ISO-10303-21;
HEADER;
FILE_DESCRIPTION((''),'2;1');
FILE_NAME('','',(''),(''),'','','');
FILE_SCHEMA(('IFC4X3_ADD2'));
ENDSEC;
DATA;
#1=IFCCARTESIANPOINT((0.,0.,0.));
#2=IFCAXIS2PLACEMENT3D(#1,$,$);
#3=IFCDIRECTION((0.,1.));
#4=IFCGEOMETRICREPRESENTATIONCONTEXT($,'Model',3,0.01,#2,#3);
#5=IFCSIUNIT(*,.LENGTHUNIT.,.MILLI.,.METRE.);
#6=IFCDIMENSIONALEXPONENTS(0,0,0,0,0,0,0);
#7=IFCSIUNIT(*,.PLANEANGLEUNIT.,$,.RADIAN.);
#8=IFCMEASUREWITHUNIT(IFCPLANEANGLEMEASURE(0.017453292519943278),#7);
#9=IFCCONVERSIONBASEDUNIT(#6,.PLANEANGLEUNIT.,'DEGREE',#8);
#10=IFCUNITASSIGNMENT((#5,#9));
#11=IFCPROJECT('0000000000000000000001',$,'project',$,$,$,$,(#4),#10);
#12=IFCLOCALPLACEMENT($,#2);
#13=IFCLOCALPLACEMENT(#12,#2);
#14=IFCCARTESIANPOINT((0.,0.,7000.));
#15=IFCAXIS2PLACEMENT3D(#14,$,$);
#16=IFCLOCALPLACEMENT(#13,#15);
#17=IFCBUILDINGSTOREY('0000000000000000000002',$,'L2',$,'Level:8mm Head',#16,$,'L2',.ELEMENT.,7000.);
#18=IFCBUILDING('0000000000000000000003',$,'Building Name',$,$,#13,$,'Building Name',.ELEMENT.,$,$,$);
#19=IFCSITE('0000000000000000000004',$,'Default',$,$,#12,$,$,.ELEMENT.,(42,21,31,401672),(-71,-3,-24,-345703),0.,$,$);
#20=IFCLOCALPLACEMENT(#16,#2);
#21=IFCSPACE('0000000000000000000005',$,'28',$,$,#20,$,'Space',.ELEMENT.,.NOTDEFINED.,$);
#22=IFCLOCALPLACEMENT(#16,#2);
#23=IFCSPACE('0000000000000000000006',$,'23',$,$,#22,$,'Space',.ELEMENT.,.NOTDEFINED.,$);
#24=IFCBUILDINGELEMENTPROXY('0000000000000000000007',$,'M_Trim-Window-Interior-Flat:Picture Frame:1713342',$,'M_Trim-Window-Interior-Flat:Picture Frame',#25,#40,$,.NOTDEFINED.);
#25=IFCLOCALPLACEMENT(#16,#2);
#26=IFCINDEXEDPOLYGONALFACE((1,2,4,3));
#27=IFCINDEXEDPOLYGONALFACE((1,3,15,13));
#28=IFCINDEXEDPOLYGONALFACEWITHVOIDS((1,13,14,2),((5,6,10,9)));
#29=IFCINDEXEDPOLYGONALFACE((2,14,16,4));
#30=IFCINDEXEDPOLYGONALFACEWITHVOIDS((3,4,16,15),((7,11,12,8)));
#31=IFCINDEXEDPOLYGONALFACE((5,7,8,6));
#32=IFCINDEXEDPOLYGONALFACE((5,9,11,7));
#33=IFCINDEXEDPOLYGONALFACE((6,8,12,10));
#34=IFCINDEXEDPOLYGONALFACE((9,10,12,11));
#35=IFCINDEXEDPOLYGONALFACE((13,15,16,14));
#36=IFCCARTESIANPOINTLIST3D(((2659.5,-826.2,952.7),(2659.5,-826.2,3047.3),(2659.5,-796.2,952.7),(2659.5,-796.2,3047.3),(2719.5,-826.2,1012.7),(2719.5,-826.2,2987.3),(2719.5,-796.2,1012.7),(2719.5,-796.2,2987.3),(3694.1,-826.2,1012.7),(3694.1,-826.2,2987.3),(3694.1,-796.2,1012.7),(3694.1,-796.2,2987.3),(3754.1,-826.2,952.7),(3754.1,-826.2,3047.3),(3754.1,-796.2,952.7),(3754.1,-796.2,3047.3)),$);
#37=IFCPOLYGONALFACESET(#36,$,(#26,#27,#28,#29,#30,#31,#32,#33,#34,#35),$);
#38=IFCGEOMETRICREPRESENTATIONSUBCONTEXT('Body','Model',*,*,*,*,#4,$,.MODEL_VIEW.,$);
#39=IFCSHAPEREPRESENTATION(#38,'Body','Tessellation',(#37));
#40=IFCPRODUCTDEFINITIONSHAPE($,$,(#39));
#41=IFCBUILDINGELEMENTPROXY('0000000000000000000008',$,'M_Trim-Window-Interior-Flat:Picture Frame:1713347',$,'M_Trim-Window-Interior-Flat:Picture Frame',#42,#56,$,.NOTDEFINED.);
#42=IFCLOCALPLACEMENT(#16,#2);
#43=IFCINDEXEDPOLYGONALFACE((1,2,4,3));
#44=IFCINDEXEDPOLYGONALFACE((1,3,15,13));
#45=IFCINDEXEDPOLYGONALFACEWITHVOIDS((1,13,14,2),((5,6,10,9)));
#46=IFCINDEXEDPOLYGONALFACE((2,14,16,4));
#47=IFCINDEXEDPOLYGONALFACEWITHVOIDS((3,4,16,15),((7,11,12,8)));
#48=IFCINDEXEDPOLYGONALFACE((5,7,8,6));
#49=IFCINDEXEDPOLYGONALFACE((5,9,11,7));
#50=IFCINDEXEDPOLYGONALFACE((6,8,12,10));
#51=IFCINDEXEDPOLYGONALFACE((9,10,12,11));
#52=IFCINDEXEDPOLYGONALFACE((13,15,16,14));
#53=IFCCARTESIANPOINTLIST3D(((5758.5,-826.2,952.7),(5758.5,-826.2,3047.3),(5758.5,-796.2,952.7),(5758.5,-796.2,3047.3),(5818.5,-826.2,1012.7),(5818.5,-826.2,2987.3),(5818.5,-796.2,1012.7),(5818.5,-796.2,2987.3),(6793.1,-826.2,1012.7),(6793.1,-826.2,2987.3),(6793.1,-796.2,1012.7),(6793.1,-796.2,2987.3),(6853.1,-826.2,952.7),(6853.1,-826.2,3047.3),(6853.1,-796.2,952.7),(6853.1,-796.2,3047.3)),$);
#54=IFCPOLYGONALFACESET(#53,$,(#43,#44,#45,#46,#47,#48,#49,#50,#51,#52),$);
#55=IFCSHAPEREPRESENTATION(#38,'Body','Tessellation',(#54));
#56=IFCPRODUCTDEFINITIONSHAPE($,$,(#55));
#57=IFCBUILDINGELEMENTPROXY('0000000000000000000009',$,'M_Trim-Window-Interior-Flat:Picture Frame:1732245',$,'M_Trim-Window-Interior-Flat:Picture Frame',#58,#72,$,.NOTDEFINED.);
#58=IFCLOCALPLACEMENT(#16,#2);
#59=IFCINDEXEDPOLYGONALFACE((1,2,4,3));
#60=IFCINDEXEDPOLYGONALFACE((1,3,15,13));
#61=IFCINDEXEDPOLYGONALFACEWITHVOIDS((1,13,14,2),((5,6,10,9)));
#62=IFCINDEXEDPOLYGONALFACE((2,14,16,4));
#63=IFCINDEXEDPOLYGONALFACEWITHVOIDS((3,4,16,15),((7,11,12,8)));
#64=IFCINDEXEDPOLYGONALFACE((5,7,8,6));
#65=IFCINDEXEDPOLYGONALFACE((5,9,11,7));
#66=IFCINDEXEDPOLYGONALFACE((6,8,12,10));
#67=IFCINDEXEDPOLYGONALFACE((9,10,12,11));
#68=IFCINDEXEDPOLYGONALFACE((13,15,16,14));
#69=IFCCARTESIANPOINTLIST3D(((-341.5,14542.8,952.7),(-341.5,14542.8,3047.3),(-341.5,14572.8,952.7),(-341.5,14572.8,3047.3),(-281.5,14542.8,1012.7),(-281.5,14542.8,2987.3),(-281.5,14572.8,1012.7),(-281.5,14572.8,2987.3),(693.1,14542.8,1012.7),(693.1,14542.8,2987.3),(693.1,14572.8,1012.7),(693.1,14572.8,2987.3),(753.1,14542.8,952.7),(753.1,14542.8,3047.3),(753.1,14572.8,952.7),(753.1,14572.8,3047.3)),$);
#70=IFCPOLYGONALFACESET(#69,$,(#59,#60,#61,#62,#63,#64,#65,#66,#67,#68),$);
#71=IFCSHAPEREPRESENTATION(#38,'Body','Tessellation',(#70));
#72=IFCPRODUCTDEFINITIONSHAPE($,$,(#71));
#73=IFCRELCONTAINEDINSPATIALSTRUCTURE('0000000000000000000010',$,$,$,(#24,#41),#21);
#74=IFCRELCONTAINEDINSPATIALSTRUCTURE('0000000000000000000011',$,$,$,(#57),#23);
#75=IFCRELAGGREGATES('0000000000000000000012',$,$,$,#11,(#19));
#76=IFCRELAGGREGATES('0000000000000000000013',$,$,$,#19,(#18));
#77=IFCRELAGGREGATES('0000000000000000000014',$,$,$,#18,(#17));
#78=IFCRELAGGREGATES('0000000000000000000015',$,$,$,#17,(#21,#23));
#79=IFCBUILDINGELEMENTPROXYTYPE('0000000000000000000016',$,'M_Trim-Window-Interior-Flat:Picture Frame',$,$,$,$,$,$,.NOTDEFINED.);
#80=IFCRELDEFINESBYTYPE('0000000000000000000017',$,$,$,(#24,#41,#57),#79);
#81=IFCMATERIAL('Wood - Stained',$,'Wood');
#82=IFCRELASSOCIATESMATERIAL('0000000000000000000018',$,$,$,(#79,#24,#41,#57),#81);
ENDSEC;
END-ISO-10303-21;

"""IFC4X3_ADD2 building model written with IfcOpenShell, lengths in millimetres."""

from ifc_helpers import new_model, entity, si_unit, converted_unit, direction, frame, origin, place, context, subcontext, project, spatial, polyline, outline, extrude, source, transform, mapped, material, type_object, type_shapes, element, save


model = new_model("IFC4X3_ADD2")

# Units and contexts
model_context = context("Model", 3, precision=0.01, world=origin(), true_north=direction((0.0, 1.0)))
body_context = subcontext(model_context, "Body", "Model", "MODEL_VIEW")
ifc_project = project(units=[si_unit("LENGTHUNIT", "METRE", prefix="MILLI"), converted_unit("PLANEANGLEUNIT", "DEGREE", entity("IfcPlaneAngleMeasure", 0.017453292519943278), si_unit("PLANEANGLEUNIT", "RADIAN"), dimensions=[0, 0, 0, 0, 0, 0, 0])], contexts=[model_context])

# Site, building, storey
site_placement = place(None, origin())
site = spatial("IfcSite", under=ifc_project, at=site_placement, Name="Default", CompositionType="ELEMENT", RefLatitude=(42, 21, 31, 401672), RefLongitude=(-71, -3, -24, -345703), RefElevation=0.0)
building_placement = place(site_placement, origin())
building = spatial("IfcBuilding", under=site, at=building_placement, Name="Building Name", LongName="Building Name", CompositionType="ELEMENT")
storey_placement = place(building_placement, frame((0.0, 0.0, 7000.0)))
storey = spatial("IfcBuildingStorey", under=building, at=storey_placement, Name="L2", ObjectType="Level:8mm Head", LongName="L2", CompositionType="ELEMENT", Elevation=7000.0)

# Shared definitions
ifc_material_1 = material(Name="Wood - Stained", Category="Wood")

# Shared definitions
space_1_placement = place(storey_placement, origin())
space_1 = spatial("IfcSpace", under=storey, at=space_1_placement, Name="28", LongName="Space", CompositionType="ELEMENT", PredefinedType="NOTDEFINED")

# Building element proxies
building_element_proxy_type_1 = type_object("IfcBuildingElementProxyType", Name="M_Trim-Window-Interior-Flat:Picture Frame", PredefinedType="NOTDEFINED", material=ifc_material_1)
shared_shape_1 = source(origin(), body_context, "Body", "SweptSolid", [
    extrude(outline(polyline([(-547.3, -1047.3), (547.3, -1047.3), (547.3, 1047.3), (-547.3, 1047.3), (-547.3, -1047.3)]), holes=[polyline([(-487.3, -987.3), (-487.3, 987.3), (487.3, 987.3), (487.3, -987.3), (-487.3, -987.3)])]), frame((0.0, -1000.0, 0.0), z_axis=(0.0, 0.0, 1.0), x_axis=(-1.0, 0.0, 0.0)), (0.0, 0.0, 1.0), 30.0),
])
type_shapes(building_element_proxy_type_1, [shared_shape_1])
for number, where, z_axis, x_axis, name in (
    (1, (3206.8, -826.2, 3000.0), (0.0, 1.0, 0.0), (-1.0, 0.0, 0.0), "M_Trim-Window-Interior-Flat:Picture Frame:1713342"),
    (2, (6305.8, -826.2, 3000.0), (0.0, 1.0, 0.0), (-1.0, 0.0, 0.0), "M_Trim-Window-Interior-Flat:Picture Frame:1713347"),
):
    element("IfcBuildingElementProxy", number, at=place(space_1_placement, frame(where, z_axis=z_axis, x_axis=x_axis)), inside=space_1, type_object=building_element_proxy_type_1, material=ifc_material_1, Name=name, ObjectType="M_Trim-Window-Interior-Flat:Picture Frame", PredefinedType="NOTDEFINED", context=body_context, shape_type="MappedRepresentation", body=[
        mapped(shared_shape_1, transform((0.0, 0.0, 0.0), scale=1.0)),
    ])

# Shared definitions
space_2_placement = place(storey_placement, origin())
space_2 = spatial("IfcSpace", under=storey, at=space_2_placement, Name="23", LongName="Space", CompositionType="ELEMENT", PredefinedType="NOTDEFINED")

# Building element proxy
proxy_1_placement = place(space_2_placement, frame((205.8, 14572.8, 3000.0), z_axis=(0.0, -1.0, 0.0), x_axis=(1.0, 0.0, 0.0)))
element("IfcBuildingElementProxy", 3, at=proxy_1_placement, inside=space_2, type_object=building_element_proxy_type_1, material=ifc_material_1, Name="M_Trim-Window-Interior-Flat:Picture Frame:1732245", ObjectType="M_Trim-Window-Interior-Flat:Picture Frame", PredefinedType="NOTDEFINED", context=body_context, shape_type="MappedRepresentation", body=[
    mapped(shared_shape_1, transform((0.0, 0.0, 0.0), scale=1.0)),
])

save(model, "model.ifc")
